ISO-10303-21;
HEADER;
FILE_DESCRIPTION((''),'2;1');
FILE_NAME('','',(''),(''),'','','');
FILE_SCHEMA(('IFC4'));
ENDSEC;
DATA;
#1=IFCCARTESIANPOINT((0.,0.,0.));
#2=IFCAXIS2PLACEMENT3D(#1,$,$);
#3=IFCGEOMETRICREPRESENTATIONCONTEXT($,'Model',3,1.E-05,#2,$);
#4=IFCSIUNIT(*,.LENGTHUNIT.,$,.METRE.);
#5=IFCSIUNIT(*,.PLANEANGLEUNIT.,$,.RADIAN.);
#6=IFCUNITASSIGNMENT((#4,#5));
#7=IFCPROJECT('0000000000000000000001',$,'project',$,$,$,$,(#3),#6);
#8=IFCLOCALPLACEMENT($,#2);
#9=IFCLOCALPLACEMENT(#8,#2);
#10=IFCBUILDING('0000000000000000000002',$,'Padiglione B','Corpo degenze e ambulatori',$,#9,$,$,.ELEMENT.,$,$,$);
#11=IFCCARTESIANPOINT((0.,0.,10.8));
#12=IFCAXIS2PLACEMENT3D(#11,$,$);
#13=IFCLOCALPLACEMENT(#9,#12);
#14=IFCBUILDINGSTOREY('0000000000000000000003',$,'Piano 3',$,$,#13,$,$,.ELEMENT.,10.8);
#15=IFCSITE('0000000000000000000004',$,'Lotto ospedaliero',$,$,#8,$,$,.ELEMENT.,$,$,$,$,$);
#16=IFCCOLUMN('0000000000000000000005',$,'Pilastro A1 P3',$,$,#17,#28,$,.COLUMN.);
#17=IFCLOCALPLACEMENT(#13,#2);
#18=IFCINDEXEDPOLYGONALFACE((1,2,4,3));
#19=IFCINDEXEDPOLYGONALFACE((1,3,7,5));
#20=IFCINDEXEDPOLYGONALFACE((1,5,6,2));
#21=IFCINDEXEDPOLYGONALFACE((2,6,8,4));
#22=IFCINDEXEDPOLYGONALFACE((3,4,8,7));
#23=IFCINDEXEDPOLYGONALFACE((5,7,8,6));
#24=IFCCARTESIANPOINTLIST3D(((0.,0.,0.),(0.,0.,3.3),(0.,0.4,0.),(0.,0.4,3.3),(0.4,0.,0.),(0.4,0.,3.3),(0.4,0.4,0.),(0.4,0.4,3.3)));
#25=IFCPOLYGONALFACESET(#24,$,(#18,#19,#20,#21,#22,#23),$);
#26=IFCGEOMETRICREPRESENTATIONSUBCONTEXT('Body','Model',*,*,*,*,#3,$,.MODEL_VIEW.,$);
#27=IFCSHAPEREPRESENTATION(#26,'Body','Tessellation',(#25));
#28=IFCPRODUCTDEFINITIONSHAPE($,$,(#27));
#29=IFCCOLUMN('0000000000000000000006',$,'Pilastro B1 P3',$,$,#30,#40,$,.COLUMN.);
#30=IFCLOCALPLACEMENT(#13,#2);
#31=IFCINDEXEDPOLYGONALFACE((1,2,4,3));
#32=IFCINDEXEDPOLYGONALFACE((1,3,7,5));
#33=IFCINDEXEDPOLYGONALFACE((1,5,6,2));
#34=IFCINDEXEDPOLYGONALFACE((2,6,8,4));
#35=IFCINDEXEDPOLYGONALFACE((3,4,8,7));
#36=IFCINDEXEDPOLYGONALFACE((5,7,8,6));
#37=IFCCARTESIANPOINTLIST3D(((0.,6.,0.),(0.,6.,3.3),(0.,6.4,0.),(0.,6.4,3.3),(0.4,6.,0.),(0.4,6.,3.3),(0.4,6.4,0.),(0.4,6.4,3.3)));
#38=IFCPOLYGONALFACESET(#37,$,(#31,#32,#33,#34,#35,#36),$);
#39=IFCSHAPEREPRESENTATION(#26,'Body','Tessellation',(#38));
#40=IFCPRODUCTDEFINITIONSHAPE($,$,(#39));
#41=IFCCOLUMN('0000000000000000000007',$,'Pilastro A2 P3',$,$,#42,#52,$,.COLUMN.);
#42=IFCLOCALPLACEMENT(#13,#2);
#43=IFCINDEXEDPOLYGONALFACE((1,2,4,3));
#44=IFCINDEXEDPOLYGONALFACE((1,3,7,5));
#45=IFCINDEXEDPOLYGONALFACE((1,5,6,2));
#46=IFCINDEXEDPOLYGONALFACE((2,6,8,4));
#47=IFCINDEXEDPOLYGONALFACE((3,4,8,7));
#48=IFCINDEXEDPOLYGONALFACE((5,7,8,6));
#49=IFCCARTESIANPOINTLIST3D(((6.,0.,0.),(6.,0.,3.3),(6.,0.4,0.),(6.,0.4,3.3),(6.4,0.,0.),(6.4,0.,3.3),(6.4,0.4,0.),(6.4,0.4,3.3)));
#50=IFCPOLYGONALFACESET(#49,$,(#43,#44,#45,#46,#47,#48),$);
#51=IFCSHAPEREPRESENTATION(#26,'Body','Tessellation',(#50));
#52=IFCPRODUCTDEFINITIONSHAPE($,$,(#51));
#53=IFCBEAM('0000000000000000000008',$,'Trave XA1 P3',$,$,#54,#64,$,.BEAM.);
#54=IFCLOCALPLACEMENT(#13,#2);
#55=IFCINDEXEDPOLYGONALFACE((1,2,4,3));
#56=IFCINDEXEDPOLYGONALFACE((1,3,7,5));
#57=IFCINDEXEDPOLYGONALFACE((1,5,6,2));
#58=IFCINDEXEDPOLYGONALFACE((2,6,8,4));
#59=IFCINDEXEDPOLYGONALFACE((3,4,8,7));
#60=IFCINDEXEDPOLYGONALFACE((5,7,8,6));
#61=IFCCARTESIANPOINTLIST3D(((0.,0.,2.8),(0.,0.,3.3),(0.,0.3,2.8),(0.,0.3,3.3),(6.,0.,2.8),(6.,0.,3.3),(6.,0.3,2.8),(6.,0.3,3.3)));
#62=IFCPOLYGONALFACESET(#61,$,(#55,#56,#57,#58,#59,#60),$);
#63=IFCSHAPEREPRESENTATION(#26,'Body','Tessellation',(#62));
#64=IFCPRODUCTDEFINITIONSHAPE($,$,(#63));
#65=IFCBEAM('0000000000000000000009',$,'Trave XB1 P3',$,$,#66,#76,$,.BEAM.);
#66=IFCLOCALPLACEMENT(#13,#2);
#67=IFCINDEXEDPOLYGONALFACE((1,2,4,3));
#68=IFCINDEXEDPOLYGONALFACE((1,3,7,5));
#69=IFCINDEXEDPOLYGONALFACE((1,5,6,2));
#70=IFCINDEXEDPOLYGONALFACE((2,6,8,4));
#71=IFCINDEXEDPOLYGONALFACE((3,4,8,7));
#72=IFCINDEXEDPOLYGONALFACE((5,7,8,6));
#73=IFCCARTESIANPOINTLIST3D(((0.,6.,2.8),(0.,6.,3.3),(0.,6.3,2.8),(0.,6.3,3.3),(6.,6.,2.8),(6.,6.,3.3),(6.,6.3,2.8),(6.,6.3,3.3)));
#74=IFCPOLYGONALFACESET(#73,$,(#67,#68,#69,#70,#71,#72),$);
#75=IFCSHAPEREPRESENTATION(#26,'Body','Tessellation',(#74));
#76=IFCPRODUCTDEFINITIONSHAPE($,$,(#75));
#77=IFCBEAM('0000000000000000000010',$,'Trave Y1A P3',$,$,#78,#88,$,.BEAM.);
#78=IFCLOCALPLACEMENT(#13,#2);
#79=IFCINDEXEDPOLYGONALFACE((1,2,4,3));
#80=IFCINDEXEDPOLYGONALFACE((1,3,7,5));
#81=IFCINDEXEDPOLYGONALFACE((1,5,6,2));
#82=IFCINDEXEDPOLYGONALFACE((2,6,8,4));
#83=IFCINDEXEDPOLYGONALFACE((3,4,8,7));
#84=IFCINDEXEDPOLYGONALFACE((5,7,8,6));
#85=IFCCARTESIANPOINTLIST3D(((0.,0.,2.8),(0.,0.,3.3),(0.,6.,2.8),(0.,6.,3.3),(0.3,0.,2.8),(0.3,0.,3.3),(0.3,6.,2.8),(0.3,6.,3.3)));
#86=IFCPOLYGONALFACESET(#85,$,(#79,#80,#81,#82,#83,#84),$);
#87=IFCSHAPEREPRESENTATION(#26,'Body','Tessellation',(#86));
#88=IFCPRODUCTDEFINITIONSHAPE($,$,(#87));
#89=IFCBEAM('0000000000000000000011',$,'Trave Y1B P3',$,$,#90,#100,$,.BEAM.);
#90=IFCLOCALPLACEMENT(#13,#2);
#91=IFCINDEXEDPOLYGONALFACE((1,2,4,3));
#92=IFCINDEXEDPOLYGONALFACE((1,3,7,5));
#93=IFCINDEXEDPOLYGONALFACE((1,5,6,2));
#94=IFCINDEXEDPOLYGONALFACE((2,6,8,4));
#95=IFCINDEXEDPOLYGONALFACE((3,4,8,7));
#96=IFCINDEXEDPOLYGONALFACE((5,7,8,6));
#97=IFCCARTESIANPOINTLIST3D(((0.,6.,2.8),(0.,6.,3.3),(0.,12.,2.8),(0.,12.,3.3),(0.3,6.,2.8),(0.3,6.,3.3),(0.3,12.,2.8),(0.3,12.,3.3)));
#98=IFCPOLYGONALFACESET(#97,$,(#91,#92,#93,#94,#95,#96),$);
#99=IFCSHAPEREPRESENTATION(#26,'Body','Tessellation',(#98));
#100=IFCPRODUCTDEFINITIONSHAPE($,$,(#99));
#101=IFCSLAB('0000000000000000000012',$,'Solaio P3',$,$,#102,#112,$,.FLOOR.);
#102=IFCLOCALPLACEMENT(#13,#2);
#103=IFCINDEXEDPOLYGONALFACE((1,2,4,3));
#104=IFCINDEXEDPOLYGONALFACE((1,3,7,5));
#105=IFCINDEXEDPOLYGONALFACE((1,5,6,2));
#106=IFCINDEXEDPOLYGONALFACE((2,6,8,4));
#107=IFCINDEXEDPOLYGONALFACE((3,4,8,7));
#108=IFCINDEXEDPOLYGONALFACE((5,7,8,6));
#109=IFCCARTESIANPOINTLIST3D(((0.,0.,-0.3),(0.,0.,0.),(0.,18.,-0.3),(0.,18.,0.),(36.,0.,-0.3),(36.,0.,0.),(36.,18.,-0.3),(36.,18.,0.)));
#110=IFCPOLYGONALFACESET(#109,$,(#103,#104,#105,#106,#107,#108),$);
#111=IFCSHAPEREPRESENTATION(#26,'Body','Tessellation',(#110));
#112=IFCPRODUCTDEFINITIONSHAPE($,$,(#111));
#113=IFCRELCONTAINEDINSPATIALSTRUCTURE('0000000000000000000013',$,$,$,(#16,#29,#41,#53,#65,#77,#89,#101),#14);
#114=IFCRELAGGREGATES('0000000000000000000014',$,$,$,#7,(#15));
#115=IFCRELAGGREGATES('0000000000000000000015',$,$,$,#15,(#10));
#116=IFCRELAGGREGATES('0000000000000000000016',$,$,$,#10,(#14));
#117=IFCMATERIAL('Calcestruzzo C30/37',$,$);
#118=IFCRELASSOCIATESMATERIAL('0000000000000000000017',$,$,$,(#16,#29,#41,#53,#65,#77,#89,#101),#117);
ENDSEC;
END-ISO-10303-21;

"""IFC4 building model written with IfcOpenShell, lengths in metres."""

from ifc_helpers import new_model, si_unit, frame, frame_2d, origin, place, context, subcontext, project, spatial, rectangle, extrude, material, element, save


model = new_model("IFC4")

# Units and contexts
model_context = context("Model", 3, precision=1e-05, world=origin())
body_context = subcontext(model_context, "Body", "Model", "MODEL_VIEW")
ifc_project = project(units=[si_unit("LENGTHUNIT", "METRE"), si_unit("PLANEANGLEUNIT", "RADIAN")], contexts=[model_context])

# Site, building, storey
site_placement = place(None, origin())
site = spatial("IfcSite", under=ifc_project, at=site_placement, Name="Lotto ospedaliero", CompositionType="ELEMENT")
building_placement = place(site_placement, origin())
building = spatial("IfcBuilding", under=site, at=building_placement, Name="Padiglione B", Description="Corpo degenze e ambulatori", CompositionType="ELEMENT")
storey_placement = place(building_placement, frame((0.0, 0.0, 10.8)))
storey = spatial("IfcBuildingStorey", under=building, at=storey_placement, Name="Piano 3", CompositionType="ELEMENT", Elevation=10.8)

# Columns
ifc_material_1 = material(Name="Calcestruzzo C30/37")
for number, where, name in (
    (1, (0.0, 0.0, 0.0), "Pilastro A1 P3"),
    (2, (0.0, 6.0, 0.0), "Pilastro B1 P3"),
    (3, (6.0, 0.0, 0.0), "Pilastro A2 P3"),
):
    element("IfcColumn", number, at=place(storey_placement, frame(where)), inside=storey, material=ifc_material_1, Name=name, PredefinedType="COLUMN", context=body_context, shape_type="SweptSolid", body=[
        extrude(rectangle(XDim=0.4, YDim=0.4, at=frame_2d((0.2, 0.2))), origin(), (0.0, 0.0, 1.0), 3.3),
    ])

# Beams
for number, where, name in (
    (4, (0.0, 0.0, 2.8), "Trave XA1 P3"),
    (5, (0.0, 6.0, 2.8), "Trave XB1 P3"),
):
    element("IfcBeam", number, at=place(storey_placement, frame(where)), inside=storey, material=ifc_material_1, Name=name, PredefinedType="BEAM", context=body_context, shape_type="SweptSolid", body=[
        extrude(rectangle(XDim=6.0, YDim=0.3, at=frame_2d((3.0, 0.15))), origin(), (0.0, 0.0, 1.0), 0.5),
    ])
for number, where, name in (
    (6, (0.0, 0.0, 2.8), "Trave Y1A P3"),
    (7, (0.0, 6.0, 2.8), "Trave Y1B P3"),
):
    element("IfcBeam", number, at=place(storey_placement, frame(where)), inside=storey, material=ifc_material_1, Name=name, PredefinedType="BEAM", context=body_context, shape_type="SweptSolid", body=[
        extrude(rectangle(XDim=0.3, YDim=6.0, at=frame_2d((0.15, 3.0))), origin(), (0.0, 0.0, 1.0), 0.5),
    ])

# Slab
slab_placement = place(storey_placement, frame((0.0, 0.0, -0.3)))
element("IfcSlab", 8, at=slab_placement, inside=storey, material=ifc_material_1, Name="Solaio P3", PredefinedType="FLOOR", context=body_context, shape_type="SweptSolid", body=[
    extrude(rectangle(XDim=36.0, YDim=18.0, at=frame_2d((18.0, 9.0))), origin(), (0.0, 0.0, 1.0), 0.3),
])

save(model, "model.ifc")
